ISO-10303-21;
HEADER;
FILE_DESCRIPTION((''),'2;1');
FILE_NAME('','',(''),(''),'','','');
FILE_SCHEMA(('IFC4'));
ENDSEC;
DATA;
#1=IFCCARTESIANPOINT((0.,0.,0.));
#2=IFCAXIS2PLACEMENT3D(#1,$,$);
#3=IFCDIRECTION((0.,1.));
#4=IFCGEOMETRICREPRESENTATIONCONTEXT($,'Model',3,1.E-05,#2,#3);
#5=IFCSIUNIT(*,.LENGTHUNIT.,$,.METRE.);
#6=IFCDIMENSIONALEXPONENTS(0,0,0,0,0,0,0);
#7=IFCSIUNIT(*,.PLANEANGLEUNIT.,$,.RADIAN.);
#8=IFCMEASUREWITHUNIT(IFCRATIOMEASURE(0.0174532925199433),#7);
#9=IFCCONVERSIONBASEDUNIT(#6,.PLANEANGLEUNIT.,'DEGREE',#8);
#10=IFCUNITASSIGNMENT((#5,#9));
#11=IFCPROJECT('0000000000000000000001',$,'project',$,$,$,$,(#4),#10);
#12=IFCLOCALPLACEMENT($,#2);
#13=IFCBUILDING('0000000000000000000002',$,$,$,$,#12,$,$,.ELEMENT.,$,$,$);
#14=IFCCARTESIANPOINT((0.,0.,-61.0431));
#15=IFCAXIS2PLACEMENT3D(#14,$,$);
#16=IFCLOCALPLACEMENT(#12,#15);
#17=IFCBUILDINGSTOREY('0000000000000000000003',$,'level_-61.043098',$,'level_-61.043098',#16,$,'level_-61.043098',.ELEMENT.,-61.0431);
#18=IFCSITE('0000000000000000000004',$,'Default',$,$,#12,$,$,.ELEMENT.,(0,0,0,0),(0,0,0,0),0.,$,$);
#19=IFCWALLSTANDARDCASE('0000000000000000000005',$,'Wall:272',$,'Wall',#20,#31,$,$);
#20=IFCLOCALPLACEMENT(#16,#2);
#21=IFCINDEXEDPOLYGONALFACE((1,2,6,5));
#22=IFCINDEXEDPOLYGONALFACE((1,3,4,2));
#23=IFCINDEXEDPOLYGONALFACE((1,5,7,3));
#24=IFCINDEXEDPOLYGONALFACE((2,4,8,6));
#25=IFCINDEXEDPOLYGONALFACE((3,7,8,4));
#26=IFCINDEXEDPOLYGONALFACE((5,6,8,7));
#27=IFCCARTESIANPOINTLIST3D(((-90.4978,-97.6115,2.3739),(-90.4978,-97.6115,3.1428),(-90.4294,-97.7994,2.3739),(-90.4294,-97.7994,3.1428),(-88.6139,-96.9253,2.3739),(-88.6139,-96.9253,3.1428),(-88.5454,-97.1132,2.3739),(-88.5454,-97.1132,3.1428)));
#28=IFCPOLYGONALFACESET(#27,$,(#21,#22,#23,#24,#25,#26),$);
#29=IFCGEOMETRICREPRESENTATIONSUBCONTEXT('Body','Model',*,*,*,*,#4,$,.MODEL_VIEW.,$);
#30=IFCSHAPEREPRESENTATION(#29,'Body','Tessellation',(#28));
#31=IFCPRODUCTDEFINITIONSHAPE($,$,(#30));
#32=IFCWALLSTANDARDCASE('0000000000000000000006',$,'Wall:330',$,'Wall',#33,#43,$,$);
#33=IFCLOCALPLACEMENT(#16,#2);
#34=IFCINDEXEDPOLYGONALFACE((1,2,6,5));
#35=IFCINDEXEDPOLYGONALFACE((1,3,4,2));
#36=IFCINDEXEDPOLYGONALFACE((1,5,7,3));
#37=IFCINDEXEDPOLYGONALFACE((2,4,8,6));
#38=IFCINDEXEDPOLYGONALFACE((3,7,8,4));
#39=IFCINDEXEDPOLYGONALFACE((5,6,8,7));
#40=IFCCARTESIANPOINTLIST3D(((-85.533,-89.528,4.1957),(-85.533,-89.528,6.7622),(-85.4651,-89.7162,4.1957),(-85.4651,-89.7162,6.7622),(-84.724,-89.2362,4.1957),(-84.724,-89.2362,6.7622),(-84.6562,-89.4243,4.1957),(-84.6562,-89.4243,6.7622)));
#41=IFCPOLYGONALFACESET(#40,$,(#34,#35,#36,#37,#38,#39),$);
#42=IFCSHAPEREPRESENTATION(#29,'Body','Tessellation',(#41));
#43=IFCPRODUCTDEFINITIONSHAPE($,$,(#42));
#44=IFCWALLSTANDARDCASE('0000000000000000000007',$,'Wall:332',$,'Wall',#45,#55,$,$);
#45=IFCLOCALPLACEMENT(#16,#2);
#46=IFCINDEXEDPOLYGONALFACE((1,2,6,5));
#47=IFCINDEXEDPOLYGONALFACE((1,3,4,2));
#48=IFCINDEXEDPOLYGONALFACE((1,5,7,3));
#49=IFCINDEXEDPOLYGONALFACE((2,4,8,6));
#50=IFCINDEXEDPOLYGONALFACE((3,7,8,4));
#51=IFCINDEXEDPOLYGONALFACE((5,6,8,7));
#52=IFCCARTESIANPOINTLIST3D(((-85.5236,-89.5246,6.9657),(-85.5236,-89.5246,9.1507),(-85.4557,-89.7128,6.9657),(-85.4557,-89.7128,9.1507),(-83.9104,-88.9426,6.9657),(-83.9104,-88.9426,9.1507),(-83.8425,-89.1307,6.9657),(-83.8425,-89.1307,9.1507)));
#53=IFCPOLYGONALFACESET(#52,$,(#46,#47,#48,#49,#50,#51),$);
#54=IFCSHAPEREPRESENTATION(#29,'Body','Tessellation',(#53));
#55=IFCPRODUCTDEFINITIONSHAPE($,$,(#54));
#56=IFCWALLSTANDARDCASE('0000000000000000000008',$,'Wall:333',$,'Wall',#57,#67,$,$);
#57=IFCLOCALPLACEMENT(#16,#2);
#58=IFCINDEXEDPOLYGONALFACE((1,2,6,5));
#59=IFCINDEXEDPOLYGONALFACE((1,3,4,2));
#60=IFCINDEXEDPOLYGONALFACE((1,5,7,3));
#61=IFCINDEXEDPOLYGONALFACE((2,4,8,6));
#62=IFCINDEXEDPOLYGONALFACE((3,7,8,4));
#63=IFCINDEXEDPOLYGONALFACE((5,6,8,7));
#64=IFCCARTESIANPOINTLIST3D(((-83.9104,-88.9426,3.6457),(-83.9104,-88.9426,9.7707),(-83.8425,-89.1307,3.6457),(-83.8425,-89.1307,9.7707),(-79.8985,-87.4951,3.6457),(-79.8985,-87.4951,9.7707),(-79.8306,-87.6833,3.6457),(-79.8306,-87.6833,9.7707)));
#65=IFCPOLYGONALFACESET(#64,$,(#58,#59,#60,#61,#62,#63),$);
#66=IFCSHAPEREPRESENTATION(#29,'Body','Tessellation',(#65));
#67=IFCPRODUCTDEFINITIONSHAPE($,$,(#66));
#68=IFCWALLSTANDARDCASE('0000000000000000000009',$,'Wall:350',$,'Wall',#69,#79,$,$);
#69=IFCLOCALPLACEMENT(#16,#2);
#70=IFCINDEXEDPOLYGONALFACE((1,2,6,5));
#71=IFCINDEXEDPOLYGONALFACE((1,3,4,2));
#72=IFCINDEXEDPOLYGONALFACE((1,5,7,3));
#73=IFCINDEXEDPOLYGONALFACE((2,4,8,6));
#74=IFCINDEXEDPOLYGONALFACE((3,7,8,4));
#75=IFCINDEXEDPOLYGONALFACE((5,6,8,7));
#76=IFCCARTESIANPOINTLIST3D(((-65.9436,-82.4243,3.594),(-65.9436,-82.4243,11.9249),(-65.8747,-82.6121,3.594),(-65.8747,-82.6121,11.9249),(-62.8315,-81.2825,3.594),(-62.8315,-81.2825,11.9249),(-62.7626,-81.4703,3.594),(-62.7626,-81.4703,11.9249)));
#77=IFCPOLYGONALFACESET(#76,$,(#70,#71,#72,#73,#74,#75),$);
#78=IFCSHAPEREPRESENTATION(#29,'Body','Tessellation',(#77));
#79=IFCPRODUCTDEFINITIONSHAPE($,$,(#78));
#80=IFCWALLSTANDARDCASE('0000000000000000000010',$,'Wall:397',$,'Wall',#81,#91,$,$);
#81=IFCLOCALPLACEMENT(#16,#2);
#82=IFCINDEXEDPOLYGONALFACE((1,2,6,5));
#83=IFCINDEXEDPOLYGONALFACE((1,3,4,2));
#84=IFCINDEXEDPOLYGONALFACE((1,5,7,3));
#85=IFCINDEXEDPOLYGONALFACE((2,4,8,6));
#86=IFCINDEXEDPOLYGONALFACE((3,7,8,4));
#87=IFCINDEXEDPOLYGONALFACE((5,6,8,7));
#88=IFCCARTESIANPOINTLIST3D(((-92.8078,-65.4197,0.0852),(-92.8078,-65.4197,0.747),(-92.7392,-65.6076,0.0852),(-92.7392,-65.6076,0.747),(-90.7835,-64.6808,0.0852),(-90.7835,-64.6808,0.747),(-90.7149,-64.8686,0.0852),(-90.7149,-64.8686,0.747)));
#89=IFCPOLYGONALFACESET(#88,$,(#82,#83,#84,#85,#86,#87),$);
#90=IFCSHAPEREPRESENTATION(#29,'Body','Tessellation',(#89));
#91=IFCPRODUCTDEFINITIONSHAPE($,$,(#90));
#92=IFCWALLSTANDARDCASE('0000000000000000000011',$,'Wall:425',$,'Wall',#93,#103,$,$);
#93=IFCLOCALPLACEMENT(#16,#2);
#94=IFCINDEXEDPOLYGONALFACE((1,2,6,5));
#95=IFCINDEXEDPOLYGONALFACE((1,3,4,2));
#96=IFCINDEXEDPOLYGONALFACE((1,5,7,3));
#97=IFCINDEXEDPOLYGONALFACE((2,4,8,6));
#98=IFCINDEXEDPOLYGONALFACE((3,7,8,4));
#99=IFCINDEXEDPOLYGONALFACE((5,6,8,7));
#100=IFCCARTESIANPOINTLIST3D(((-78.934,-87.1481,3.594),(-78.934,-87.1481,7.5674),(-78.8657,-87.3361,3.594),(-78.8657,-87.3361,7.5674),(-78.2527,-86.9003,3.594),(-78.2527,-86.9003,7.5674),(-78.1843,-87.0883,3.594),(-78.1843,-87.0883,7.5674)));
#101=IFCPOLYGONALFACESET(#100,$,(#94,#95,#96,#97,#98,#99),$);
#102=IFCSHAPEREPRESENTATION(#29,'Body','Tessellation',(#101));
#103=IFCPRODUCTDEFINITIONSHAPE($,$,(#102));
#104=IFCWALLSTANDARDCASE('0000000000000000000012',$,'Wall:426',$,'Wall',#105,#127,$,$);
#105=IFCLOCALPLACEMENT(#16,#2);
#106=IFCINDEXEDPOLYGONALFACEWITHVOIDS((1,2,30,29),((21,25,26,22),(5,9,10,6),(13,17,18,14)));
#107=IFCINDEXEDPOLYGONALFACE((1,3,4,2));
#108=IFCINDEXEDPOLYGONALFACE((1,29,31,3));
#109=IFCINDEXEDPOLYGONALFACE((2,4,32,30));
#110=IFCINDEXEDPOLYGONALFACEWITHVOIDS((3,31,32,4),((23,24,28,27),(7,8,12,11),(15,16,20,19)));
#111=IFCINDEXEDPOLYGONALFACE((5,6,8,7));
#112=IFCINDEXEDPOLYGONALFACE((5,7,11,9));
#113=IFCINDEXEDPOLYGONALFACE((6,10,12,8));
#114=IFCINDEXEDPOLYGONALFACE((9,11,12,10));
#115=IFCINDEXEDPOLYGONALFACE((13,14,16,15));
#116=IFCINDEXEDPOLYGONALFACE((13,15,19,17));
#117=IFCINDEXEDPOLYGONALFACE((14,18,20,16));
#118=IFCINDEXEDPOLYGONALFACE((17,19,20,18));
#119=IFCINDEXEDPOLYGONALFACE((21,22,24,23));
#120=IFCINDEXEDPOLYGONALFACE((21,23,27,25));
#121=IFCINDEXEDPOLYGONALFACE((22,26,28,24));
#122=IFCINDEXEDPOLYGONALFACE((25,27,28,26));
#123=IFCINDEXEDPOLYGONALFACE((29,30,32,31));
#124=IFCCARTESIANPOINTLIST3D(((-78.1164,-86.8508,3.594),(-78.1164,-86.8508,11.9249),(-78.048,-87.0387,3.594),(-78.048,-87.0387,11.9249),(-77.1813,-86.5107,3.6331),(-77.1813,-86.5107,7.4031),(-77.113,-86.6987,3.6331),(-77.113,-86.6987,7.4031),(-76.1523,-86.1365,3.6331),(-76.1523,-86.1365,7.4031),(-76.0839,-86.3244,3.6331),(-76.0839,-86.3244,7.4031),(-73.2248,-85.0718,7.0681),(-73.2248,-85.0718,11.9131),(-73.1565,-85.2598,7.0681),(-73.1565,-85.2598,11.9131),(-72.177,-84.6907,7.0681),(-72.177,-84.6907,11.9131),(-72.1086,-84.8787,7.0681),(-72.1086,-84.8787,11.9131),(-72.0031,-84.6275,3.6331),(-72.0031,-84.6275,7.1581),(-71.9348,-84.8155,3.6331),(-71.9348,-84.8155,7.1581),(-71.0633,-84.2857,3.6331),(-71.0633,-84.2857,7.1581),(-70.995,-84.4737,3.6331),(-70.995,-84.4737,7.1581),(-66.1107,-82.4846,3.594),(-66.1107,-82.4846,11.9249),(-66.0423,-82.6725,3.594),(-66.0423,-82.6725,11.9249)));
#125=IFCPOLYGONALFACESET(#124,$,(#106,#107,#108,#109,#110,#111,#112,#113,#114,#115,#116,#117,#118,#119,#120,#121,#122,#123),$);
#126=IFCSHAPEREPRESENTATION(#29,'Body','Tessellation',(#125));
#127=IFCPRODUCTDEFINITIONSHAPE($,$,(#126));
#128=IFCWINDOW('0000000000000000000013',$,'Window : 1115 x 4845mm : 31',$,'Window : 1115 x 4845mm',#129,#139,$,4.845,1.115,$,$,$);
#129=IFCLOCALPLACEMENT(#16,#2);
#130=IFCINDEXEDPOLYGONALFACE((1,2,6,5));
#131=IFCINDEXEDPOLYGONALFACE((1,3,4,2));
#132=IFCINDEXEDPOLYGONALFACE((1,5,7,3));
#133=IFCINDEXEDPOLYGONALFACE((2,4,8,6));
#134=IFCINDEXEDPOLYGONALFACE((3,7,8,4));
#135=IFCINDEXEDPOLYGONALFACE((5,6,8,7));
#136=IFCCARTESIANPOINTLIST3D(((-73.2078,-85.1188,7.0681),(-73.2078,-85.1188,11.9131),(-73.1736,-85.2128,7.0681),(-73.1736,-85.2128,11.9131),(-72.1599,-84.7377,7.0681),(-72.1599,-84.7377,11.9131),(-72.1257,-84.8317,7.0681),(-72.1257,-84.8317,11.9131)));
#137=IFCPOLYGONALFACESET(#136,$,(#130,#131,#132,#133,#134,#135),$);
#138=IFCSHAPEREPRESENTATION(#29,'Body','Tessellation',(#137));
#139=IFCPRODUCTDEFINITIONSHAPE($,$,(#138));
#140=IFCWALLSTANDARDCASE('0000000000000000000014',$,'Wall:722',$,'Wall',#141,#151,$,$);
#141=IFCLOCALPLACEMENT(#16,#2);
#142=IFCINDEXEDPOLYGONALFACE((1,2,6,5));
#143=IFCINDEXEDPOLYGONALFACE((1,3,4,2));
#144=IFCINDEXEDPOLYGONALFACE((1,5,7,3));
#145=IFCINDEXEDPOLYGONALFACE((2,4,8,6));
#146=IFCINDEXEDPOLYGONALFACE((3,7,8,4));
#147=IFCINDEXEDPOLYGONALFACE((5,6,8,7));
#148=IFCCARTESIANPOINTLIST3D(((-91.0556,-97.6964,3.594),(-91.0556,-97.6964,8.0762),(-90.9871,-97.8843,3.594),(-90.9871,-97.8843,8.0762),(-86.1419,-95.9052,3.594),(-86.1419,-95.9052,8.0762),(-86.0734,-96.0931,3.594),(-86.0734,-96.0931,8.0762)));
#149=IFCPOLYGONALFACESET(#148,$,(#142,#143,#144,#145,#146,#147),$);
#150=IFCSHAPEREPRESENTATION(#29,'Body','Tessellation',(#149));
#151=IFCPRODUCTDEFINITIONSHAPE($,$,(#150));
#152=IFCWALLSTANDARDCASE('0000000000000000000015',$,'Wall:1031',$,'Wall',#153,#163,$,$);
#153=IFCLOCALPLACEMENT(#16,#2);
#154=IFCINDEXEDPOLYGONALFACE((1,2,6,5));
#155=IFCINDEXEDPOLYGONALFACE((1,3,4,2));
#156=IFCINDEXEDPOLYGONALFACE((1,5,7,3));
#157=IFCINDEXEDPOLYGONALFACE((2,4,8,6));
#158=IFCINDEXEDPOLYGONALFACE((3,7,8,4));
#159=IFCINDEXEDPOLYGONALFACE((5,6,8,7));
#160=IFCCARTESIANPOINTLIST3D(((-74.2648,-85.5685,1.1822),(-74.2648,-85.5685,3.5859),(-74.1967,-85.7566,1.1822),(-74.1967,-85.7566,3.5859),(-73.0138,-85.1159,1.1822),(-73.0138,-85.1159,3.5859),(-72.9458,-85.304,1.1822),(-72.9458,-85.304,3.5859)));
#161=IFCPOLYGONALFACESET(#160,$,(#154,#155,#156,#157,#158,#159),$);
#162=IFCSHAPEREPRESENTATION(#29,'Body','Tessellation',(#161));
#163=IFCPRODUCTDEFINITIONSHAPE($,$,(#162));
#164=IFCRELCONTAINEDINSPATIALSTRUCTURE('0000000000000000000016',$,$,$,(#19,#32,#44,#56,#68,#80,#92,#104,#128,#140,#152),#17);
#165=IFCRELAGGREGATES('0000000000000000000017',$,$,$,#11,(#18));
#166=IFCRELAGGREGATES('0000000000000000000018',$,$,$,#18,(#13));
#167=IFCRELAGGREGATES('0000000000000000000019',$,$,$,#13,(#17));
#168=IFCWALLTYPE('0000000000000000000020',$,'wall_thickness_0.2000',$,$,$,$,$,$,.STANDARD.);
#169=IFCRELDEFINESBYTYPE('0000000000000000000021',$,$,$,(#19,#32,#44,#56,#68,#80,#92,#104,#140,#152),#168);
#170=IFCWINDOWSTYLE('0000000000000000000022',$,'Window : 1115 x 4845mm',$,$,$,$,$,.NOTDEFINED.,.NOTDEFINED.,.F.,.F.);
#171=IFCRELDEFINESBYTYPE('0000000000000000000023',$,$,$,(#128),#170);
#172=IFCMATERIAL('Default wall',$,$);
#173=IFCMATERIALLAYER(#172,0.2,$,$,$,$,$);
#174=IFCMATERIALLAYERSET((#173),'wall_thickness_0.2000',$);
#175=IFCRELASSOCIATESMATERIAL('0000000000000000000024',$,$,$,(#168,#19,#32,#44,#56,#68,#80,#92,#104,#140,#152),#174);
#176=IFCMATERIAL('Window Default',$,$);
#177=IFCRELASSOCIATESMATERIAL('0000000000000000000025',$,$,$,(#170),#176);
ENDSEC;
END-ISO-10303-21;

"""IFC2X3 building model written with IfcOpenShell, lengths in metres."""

from ifc_helpers import new_model, entity, si_unit, converted_unit, direction, frame, frame_2d, origin, origin_2d_with_axis, place, context, subcontext, project, spatial, polyline, rectangle, outline, extrude, source, transform, mapped, material, layer, layer_set, layer_usage, type_object, type_shapes, element, fill, save


model = new_model("IFC2X3")

# Units and contexts
model_context = context("Model", 3, precision=1e-05, world=origin(), true_north=direction((0.0, 1.0)))
body_context = subcontext(model_context, "Body", "Model", "MODEL_VIEW")
ifc_project = project(units=[si_unit("LENGTHUNIT", "METRE"), converted_unit("PLANEANGLEUNIT", "DEGREE", entity("IfcRatioMeasure", 0.0174532925199433), si_unit("PLANEANGLEUNIT", "RADIAN"), dimensions=[0, 0, 0, 0, 0, 0, 0])], contexts=[model_context])

# Site, building, storey
placement_1 = place(None, origin())
site = spatial("IfcSite", under=ifc_project, at=placement_1, Name="Default", CompositionType="ELEMENT", RefLatitude=(0, 0, 0, 0), RefLongitude=(0, 0, 0, 0), RefElevation=0.0)
building = spatial("IfcBuilding", under=site, at=placement_1, CompositionType="ELEMENT")
storey_placement = place(placement_1, frame((0.0, 0.0, -61.0431)))
storey = spatial("IfcBuildingStorey", under=building, at=storey_placement, Name="level_-61.043098", ObjectType="level_-61.043098", LongName="level_-61.043098", CompositionType="ELEMENT", Elevation=-61.0431)

# Walls
ifc_material_1 = material(Name="Default wall")
ifc_layer = layer(ifc_material_1, 0.2)
ifc_layer_set = layer_set([ifc_layer], Name="wall_thickness_0.2000")
ifc_layer_usage = layer_usage(ifc_layer_set, "AXIS2", "POSITIVE", -0.1)
wall_type = type_object("IfcWallType", Name="wall_thickness_0.2000", PredefinedType="STANDARD", material=ifc_layer_set)
placement_2 = place(placement_1, frame((0.0, 0.0, -58.6692)))
wall_1_placement = place(placement_2, frame((-90.4636, -97.7054, 0.0), z_axis=(0.0, 0.0, 1.0), x_axis=(0.939621, 0.342217, 0.0)))
element("IfcWallStandardCase", 1, at=wall_1_placement, inside=storey, type_object=wall_type, material=ifc_layer_usage, Name="Wall:272", ObjectType="Wall", context=body_context, shape_type="SweptSolid", body=[
    extrude(outline(polyline([(2.005, -0.1), (2.005, 0.1), (0.0, 0.1), (0.0, -0.1), (2.005, -0.1)])), origin(), (0.0, 0.0, 1.0), 0.7689),
])
placement_3 = place(placement_1, frame((0.0, 0.0, -56.8474)))
wall_2_placement = place(placement_3, frame((-84.6901, -89.3302, 0.0), z_axis=(0.0, 0.0, 1.0), x_axis=(-0.940651, -0.339375, 0.0)))
element("IfcWallStandardCase", 2, at=wall_2_placement, inside=storey, type_object=wall_type, material=ifc_layer_usage, Name="Wall:330", ObjectType="Wall", context=body_context, shape_type="SweptSolid", body=[
    extrude(outline(polyline([(0.86, -0.1), (0.86, 0.1), (0.0, 0.1), (0.0, -0.1), (0.86, -0.1)])), origin(), (0.0, 0.0, 1.0), 2.5665),
])
placement_4 = place(placement_1, frame((0.0, 0.0, -54.0774)))
wall_3_placement = place(placement_4, frame((-83.8764, -89.0367, 0.0), z_axis=(0.0, 0.0, 1.0), x_axis=(-0.94065, -0.339377, 0.0)))
element("IfcWallStandardCase", 3, at=wall_3_placement, inside=storey, type_object=wall_type, material=ifc_layer_usage, Name="Wall:332", ObjectType="Wall", context=body_context, shape_type="SweptSolid", body=[
    extrude(outline(polyline([(1.715, -0.1), (1.715, 0.1), (0.0, 0.1), (0.0, -0.1), (1.715, -0.1)])), origin(), (0.0, 0.0, 1.0), 2.185),
])
placement_5 = place(placement_1, frame((0.0, 0.0, -57.3974)))
wall_4_placement = place(placement_5, frame((-79.8646, -87.5892, 0.0), z_axis=(0.0, 0.0, 1.0), x_axis=(-0.940649, -0.33938, 0.0)))
element("IfcWallStandardCase", 4, at=wall_4_placement, inside=storey, type_object=wall_type, material=ifc_layer_usage, Name="Wall:333", ObjectType="Wall", context=body_context, shape_type="SweptSolid", body=[
    extrude(outline(polyline([(4.265, -0.1), (4.265, 0.1), (0.0, 0.1), (0.0, -0.1), (4.265, -0.1)])), origin(), (0.0, 0.0, 1.0), 6.125),
])
placement_6 = place(placement_1, frame((0.0, 0.0, -57.4491)))
wall_5_placement = place(placement_6, frame((-62.797, -81.3764, 0.0), z_axis=(0.0, 0.0, 1.0), x_axis=(-0.938815, -0.344423, 0.0)))
element("IfcWallStandardCase", 5, at=wall_5_placement, inside=storey, type_object=wall_type, material=ifc_layer_usage, Name="Wall:350", ObjectType="Wall", context=body_context, shape_type="SweptSolid", body=[
    extrude(outline(polyline([(3.315, -0.1), (3.315, 0.1), (0.0, 0.1), (0.0, -0.1), (3.315, -0.1)])), origin(), (0.0, 0.0, 1.0), 8.3309),
])
placement_7 = place(placement_1, frame((0.0, 0.0, -60.9579)))
wall_6_placement = place(placement_7, frame((-92.7735, -65.5137, 0.0), z_axis=(0.0, 0.0, 1.0), x_axis=(0.939369, 0.342908, 0.0)))
element("IfcWallStandardCase", 6, at=wall_6_placement, inside=storey, type_object=wall_type, material=ifc_layer_usage, Name="Wall:397", ObjectType="Wall", context=body_context, shape_type="SweptSolid", body=[
    extrude(outline(polyline([(2.155, -0.1), (2.155, 0.1), (0.0, 0.1), (0.0, -0.1), (2.155, -0.1)])), origin(), (0.0, 0.0, 1.0), 0.6618),
])
placement_8 = place(placement_1, frame((0.0, 0.0, -57.4491)))
wall_7_placement = place(placement_8, frame((-78.8998, -87.2421, 0.0), z_axis=(0.0, 0.0, 1.0), x_axis=(0.939782, 0.341775, 0.0)))
element("IfcWallStandardCase", 7, at=wall_7_placement, inside=storey, type_object=wall_type, material=ifc_layer_usage, Name="Wall:425", ObjectType="Wall", context=body_context, shape_type="SweptSolid", body=[
    extrude(outline(polyline([(0.725, -0.1), (0.725, 0.1), (0.0, 0.1), (0.0, -0.1), (0.725, -0.1)])), origin(), (0.0, 0.0, 1.0), 3.9734),
])

# Wall, openings, window
placement_9 = place(placement_1, frame((0.0, 0.0, -57.4491)))
wall_8_placement = place(placement_9, frame((-78.0822, -86.9447, 0.0), z_axis=(0.0, 0.0, 1.0), x_axis=(0.939781, 0.341777, 0.0)))
wall_8 = element("IfcWallStandardCase", 8, at=wall_8_placement, inside=storey, type_object=wall_type, material=ifc_layer_usage, Name="Wall:426", ObjectType="Wall", context=body_context, shape_type="SweptSolid", body=[
    extrude(outline(polyline([(12.775, -0.1), (12.775, 0.1), (0.0, 0.1), (0.0, -0.1), (12.775, -0.1)])), origin(), (0.0, 0.0, 1.0), 8.3309),
])
opening_1_placement = place(wall_8_placement, frame((0.995, -0.1, 0.0391)))
element("IfcOpeningElement", 9, at=opening_1_placement, cuts=wall_8, ObjectType="Opening", context=body_context, shape_type="SweptSolid", body=[
    extrude(rectangle(XDim=1.095, YDim=3.77, at=frame_2d((1.885, 0.5475), x_axis=(0.0, 1.0))), frame((0.0, 0.0, 0.0), z_axis=(0.0, 1.0, 0.0), x_axis=(0.0, 0.0, 1.0)), (0.0, 0.0, 1.0), 0.2),
])
opening_2_placement = place(wall_8_placement, frame((6.505, -0.1, 0.0391)))
element("IfcOpeningElement", 10, at=opening_2_placement, cuts=wall_8, ObjectType="Opening", context=body_context, shape_type="SweptSolid", body=[
    extrude(rectangle(XDim=1.0, YDim=3.525, at=frame_2d((1.7625, 0.5), x_axis=(0.0, 1.0))), frame((0.0, 0.0, 0.0), z_axis=(0.0, 1.0, 0.0), x_axis=(0.0, 0.0, 1.0)), (0.0, 0.0, 1.0), 0.2),
])
opening_3_placement = place(wall_8_placement, frame((5.205, -0.1, 3.4741)))
opening_3 = element("IfcOpeningElement", 11, at=opening_3_placement, cuts=wall_8, ObjectType="Opening", context=body_context, shape_type="SweptSolid", body=[
    extrude(rectangle(XDim=1.115, YDim=4.845, at=frame_2d((2.4225, 0.5575), x_axis=(0.0, 1.0))), frame((0.0, 0.0, 0.0), z_axis=(0.0, 1.0, 0.0), x_axis=(0.0, 0.0, 1.0)), (0.0, 0.0, 1.0), 0.2),
])
ifc_material_2 = material(Name="Window Default")
window_style_1 = type_object("IfcWindowStyle", Name="Window : 1115 x 4845mm", ConstructionType="NOTDEFINED", OperationType="NOTDEFINED", ParameterTakesPrecedence=False, Sizeable=False, material=ifc_material_2)
shared_shape_1 = source(origin(), body_context, "Body", "SweptSolid", [
    extrude(rectangle(XDim=0.1, YDim=1.115, at=origin_2d_with_axis()), frame((0.5575, 0.1, 0.0), z_axis=(0.0, 0.0, 1.0), x_axis=(0.0, 1.0, 0.0)), (0.0, 0.0, 1.0), 4.845),
])
type_shapes(window_style_1, [shared_shape_1])
window_1_placement = place(opening_3_placement, origin())
window_1 = element("IfcWindow", 12, at=window_1_placement, inside=storey, type_object=window_style_1, Name="Window : 1115 x 4845mm : 31", ObjectType="Window : 1115 x 4845mm", OverallHeight=4.845, OverallWidth=1.115, context=body_context, shape_type="MappedRepresentation", body=[
    mapped(shared_shape_1, transform((0.0, 0.0, 0.0), scale=1.0)),
])
fill(opening_3, window_1)

# Walls
placement_10 = place(placement_1, frame((0.0, 0.0, -57.4491)))
wall_9_placement = place(placement_10, frame((-86.1076, -95.9991, 0.0), z_axis=(0.0, 0.0, 1.0), x_axis=(-0.93952, -0.342494, 0.0)))
element("IfcWallStandardCase", 13, at=wall_9_placement, inside=storey, type_object=wall_type, material=ifc_layer_usage, Name="Wall:722", ObjectType="Wall", context=body_context, shape_type="SweptSolid", body=[
    extrude(outline(polyline([(5.23, -0.1), (5.23, 0.1), (0.0, 0.1), (0.0, -0.1), (5.23, -0.1)])), origin(), (0.0, 0.0, 1.0), 4.4822),
])
placement_11 = place(placement_1, frame((0.0, 0.0, -59.8609)))
wall_10_placement = place(placement_11, frame((-74.2308, -85.6625, 0.0), z_axis=(0.0, 0.0, 1.0), x_axis=(0.940345, 0.340223, 0.0)))
element("IfcWallStandardCase", 14, at=wall_10_placement, inside=storey, type_object=wall_type, material=ifc_layer_usage, Name="Wall:1031", ObjectType="Wall", context=body_context, shape_type="SweptSolid", body=[
    extrude(outline(polyline([(1.3303, -0.1), (1.3303, 0.1), (0.0, 0.1), (0.0, -0.1), (1.3303, -0.1)])), origin(), (0.0, 0.0, 1.0), 2.4037),
])

save(model, "model.ifc")
